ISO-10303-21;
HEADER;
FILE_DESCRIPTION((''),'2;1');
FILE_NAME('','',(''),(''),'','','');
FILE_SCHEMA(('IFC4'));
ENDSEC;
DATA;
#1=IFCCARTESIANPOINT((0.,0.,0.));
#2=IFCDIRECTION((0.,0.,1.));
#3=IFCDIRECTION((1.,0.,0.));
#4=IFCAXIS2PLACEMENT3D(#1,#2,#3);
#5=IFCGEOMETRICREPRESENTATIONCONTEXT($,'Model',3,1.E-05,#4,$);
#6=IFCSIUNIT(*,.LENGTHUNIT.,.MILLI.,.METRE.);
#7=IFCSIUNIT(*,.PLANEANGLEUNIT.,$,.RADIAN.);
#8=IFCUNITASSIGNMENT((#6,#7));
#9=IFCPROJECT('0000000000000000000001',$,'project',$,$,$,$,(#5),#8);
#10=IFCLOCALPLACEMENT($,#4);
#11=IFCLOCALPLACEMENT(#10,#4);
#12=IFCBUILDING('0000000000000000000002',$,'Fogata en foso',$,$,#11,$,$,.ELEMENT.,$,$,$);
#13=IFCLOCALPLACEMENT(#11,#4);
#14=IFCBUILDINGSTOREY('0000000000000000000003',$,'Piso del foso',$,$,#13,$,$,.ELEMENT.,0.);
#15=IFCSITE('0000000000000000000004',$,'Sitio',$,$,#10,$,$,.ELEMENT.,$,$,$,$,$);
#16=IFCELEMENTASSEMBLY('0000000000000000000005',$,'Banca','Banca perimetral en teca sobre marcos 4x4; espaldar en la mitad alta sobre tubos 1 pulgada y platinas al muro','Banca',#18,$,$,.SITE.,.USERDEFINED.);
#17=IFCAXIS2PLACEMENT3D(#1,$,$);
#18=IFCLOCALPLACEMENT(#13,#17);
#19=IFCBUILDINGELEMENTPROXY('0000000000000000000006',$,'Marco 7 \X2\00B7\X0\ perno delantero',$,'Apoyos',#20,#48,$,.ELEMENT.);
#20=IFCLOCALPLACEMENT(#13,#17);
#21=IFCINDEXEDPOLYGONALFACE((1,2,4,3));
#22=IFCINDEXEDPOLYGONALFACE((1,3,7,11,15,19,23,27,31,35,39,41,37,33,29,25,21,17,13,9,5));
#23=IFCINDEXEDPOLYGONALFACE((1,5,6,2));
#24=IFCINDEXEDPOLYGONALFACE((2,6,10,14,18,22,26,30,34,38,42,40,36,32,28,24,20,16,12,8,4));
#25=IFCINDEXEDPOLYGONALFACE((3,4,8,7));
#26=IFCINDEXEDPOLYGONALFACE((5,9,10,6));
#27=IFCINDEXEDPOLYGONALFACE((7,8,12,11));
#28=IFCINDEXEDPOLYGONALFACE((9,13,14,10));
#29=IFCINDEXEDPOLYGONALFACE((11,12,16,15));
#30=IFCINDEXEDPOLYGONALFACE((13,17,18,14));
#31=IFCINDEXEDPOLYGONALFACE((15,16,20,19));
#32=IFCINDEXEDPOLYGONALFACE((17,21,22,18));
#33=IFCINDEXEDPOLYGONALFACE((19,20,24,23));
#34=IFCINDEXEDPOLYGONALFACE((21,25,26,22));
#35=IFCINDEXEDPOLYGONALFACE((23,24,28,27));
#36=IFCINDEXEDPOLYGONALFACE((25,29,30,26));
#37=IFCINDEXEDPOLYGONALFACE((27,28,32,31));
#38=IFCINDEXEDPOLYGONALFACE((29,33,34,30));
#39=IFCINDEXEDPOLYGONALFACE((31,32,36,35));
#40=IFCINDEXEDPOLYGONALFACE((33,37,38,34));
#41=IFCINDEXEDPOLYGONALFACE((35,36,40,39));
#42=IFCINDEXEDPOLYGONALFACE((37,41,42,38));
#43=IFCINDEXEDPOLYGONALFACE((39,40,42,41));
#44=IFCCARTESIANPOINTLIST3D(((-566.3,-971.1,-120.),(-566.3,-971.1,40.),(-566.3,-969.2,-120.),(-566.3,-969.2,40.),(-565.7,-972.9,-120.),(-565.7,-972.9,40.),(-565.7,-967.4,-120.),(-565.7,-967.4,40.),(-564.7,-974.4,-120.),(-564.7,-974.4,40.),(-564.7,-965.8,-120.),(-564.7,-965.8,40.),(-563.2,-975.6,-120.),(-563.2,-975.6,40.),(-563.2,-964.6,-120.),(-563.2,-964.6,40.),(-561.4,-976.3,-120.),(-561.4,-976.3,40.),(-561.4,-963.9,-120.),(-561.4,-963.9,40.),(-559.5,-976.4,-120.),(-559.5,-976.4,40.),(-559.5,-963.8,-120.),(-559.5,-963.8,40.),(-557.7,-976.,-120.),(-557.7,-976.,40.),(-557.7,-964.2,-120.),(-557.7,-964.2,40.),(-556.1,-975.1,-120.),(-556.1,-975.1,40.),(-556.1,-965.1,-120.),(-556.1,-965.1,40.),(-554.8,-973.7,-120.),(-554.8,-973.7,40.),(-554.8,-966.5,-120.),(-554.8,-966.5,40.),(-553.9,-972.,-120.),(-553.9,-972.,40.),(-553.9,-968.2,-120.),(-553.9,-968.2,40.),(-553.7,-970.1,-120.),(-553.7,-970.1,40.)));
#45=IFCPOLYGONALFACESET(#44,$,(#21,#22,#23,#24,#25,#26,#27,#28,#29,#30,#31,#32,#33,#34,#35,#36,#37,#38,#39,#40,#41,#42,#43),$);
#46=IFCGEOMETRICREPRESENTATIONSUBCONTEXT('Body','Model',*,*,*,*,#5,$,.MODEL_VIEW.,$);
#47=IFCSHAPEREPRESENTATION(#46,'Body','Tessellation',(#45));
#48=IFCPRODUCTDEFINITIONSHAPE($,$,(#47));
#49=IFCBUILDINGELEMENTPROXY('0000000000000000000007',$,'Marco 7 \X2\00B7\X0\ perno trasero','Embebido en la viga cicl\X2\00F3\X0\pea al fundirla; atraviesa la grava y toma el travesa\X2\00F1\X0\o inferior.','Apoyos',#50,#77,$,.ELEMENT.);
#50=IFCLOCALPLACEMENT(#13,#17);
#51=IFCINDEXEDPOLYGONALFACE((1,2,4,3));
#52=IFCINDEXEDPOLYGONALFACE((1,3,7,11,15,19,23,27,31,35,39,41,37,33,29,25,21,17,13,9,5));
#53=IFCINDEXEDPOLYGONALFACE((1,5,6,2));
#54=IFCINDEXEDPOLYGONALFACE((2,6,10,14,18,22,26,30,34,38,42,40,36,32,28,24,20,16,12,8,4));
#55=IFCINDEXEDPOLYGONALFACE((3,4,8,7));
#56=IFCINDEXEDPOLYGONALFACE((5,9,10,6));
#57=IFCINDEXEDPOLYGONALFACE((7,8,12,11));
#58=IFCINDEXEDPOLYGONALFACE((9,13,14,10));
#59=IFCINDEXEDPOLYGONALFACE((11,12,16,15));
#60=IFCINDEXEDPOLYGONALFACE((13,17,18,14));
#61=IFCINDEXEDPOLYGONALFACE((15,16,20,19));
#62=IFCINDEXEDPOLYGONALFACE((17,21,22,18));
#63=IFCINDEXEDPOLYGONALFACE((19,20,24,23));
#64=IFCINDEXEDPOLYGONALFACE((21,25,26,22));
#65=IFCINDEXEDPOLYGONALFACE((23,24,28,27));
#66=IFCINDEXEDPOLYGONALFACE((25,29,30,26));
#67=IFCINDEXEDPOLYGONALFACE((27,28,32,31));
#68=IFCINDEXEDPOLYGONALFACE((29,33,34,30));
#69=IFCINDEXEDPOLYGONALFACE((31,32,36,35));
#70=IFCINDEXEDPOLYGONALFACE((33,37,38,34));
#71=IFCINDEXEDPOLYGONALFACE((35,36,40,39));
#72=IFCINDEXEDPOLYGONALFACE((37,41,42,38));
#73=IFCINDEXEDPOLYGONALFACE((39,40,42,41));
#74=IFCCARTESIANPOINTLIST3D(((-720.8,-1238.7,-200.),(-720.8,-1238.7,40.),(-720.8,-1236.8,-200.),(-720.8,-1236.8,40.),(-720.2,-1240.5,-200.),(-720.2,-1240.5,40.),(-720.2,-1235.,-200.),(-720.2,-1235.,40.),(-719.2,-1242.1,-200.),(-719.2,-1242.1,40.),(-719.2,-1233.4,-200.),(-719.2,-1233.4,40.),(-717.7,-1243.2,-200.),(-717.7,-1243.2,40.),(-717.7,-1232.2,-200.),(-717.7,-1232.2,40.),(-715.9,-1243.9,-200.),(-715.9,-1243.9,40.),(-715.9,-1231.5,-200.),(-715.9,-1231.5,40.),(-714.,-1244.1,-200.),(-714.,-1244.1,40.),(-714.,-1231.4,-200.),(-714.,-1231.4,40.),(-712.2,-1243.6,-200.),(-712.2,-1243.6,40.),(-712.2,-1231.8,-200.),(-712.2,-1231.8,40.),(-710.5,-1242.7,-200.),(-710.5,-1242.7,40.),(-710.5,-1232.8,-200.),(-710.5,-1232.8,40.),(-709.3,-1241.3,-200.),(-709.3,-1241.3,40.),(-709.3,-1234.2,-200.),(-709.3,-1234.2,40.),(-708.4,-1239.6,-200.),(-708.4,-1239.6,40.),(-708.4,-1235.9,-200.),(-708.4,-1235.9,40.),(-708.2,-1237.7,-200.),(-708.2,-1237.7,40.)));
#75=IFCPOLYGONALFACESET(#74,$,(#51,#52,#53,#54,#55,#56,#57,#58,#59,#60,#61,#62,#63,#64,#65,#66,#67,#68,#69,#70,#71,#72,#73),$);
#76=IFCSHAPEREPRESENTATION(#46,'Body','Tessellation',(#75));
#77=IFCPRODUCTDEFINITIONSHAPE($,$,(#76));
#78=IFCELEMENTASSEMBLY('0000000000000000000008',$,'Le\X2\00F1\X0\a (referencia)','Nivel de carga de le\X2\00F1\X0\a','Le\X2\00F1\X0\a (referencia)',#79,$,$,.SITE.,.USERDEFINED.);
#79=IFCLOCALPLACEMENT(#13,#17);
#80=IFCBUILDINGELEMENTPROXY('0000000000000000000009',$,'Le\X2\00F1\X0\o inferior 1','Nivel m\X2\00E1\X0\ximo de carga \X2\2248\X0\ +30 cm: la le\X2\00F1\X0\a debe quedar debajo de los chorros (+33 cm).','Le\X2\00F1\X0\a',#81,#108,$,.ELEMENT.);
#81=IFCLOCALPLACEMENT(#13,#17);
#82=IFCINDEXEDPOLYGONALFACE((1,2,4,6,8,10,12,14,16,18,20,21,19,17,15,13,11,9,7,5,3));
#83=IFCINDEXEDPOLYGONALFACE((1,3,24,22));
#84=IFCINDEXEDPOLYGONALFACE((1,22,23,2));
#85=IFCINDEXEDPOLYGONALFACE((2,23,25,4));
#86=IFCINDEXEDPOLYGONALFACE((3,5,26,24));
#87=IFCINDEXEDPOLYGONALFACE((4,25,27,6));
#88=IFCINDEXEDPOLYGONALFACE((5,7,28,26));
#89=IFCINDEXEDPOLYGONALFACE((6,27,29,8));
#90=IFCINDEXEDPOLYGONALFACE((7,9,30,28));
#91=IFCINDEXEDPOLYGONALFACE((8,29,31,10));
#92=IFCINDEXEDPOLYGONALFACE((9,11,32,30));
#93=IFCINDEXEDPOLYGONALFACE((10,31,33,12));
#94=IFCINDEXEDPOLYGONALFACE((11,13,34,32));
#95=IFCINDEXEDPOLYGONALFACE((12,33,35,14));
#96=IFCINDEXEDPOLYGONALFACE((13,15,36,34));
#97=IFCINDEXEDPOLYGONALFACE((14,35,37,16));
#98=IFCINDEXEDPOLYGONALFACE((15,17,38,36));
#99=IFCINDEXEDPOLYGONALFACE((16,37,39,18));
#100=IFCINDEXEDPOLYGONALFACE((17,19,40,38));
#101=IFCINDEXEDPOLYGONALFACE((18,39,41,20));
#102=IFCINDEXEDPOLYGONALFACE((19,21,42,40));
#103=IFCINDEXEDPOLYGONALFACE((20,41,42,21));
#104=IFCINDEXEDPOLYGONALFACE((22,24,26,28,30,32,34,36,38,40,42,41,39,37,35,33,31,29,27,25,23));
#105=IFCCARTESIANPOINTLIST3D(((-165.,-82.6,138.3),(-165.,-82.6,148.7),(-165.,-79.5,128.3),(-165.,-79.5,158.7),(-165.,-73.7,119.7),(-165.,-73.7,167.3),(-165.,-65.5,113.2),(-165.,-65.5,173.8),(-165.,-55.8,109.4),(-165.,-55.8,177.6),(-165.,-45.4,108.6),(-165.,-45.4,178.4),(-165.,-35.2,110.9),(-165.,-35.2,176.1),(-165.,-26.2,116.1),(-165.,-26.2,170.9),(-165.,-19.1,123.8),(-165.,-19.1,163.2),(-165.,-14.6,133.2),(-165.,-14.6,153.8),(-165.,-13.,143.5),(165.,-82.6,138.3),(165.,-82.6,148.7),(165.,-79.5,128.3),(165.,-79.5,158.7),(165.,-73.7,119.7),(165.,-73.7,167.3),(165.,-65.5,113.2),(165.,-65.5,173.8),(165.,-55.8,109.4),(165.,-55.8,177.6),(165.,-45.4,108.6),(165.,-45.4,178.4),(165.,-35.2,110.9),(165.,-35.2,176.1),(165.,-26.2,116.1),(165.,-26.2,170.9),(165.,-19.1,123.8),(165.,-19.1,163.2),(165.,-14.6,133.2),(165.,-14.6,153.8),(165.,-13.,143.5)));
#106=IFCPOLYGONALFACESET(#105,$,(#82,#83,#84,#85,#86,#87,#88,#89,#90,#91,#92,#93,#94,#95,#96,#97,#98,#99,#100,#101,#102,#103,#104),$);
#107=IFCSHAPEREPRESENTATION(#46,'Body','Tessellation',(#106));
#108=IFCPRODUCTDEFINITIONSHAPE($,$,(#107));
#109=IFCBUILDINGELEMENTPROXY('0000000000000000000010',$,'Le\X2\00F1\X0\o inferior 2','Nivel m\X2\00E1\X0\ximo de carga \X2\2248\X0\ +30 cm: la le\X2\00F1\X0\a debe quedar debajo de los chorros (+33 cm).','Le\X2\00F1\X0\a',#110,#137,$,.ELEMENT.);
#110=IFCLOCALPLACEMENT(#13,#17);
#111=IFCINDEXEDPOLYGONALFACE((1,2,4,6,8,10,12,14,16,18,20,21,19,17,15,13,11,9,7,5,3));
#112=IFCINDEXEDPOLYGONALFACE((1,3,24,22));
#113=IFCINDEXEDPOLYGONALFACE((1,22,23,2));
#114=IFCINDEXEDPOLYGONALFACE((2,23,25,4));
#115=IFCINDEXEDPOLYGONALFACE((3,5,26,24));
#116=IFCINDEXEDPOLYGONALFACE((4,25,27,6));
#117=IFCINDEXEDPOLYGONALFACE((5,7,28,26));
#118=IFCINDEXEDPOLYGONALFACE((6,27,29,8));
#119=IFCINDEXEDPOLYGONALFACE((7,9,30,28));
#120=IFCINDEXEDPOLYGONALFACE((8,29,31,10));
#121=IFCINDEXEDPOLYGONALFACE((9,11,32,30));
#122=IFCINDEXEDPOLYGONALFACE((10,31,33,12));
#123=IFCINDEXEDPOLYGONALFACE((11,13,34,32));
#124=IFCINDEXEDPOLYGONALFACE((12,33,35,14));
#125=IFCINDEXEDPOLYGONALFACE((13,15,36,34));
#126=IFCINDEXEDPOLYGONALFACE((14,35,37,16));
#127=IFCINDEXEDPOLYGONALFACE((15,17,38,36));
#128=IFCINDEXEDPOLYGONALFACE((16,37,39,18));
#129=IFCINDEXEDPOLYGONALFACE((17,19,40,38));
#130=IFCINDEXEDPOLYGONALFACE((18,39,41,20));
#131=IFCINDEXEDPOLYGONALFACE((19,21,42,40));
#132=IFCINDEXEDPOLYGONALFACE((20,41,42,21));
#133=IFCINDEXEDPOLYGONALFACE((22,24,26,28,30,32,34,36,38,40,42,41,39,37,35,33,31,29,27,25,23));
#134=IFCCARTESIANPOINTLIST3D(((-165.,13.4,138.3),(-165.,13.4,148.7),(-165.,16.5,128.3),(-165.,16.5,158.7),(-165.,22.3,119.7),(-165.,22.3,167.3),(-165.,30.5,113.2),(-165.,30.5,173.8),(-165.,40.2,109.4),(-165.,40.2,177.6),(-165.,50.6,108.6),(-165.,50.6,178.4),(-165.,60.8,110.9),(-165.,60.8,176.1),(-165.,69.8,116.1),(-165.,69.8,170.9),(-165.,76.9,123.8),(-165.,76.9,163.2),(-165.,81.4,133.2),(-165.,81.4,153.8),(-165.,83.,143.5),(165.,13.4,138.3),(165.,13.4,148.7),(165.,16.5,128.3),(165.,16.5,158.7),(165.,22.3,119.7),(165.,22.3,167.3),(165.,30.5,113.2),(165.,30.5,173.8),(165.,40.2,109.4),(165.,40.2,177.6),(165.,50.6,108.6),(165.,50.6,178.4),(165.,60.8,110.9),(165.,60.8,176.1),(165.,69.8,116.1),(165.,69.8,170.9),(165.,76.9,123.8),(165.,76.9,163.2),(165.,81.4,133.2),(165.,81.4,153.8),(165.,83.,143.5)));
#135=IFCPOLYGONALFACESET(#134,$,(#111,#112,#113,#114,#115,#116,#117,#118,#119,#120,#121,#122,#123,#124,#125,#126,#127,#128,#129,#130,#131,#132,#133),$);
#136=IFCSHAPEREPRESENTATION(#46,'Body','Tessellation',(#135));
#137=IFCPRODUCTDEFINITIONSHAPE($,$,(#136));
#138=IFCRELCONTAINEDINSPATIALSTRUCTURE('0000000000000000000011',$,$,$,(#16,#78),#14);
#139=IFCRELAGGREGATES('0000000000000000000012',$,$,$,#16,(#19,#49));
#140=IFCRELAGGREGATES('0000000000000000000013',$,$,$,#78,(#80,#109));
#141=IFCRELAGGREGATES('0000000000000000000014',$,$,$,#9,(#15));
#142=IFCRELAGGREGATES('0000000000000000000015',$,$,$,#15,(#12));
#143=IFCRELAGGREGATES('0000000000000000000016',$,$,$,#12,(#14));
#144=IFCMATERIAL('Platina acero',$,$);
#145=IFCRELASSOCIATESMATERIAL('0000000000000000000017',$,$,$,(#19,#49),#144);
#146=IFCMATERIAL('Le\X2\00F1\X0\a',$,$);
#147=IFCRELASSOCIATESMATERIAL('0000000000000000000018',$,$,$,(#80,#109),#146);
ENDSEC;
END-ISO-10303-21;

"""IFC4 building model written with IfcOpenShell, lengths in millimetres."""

from ifc_helpers import new_model, si_unit, frame, origin_with_axes, origin_2d, place, context, subcontext, project, spatial, circle, extrude, material, element, aggregate, save


model = new_model("IFC4")

# Units and contexts
model_context = context("Model", 3, precision=1e-05, world=origin_with_axes())
body_context = subcontext(model_context, "Body", "Model", "MODEL_VIEW")
ifc_project = project(units=[si_unit("LENGTHUNIT", "METRE", prefix="MILLI"), si_unit("PLANEANGLEUNIT", "RADIAN")], contexts=[model_context])

# Site, building, storey
site_placement = place(None, origin_with_axes())
site = spatial("IfcSite", under=ifc_project, at=site_placement, Name="Sitio", CompositionType="ELEMENT")
building_placement = place(site_placement, origin_with_axes())
building = spatial("IfcBuilding", under=site, at=building_placement, Name="Fogata en foso", CompositionType="ELEMENT")
storey_placement = place(building_placement, origin_with_axes())
storey = spatial("IfcBuildingStorey", under=building, at=storey_placement, Name="Piso del foso", CompositionType="ELEMENT", Elevation=0.0)

# Element assembly, building element proxies
assembly_1_placement = place(storey_placement, origin_with_axes())
assembly_1 = element("IfcElementAssembly", 1, at=assembly_1_placement, inside=storey, Name="Banca", Description="Banca perimetral en teca sobre marcos 4x4; espaldar en la mitad alta sobre tubos 1 pulgada y platinas al muro", ObjectType="Banca", AssemblyPlace="SITE", PredefinedType="USERDEFINED")
ifc_material_1 = material(Name="Platina acero")
proxy_1_placement = place(storey_placement, frame((-560.0, -970.1, -120.0), z_axis=(0.0, 0.0, 1.0), x_axis=(1.0, 0.0, 0.0)))
proxy_1 = element("IfcBuildingElementProxy", 2, at=proxy_1_placement, material=ifc_material_1, Name="Marco 7 · perno delantero", ObjectType="Apoyos", PredefinedType="ELEMENT", context=body_context, shape_type="SweptSolid", body=[
    extrude(circle(Radius=6.3, at=origin_2d()), origin_with_axes(), (0.0, 0.0, 1.0), 160.0),
])
proxy_2_placement = place(storey_placement, frame((-714.5, -1237.7, -200.0), z_axis=(0.0, 0.0, 1.0), x_axis=(1.0, 0.0, 0.0)))
proxy_2 = element("IfcBuildingElementProxy", 3, at=proxy_2_placement, material=ifc_material_1, Name="Marco 7 · perno trasero", Description="Embebido en la viga ciclópea al fundirla; atraviesa la grava y toma el travesaño inferior.", ObjectType="Apoyos", PredefinedType="ELEMENT", context=body_context, shape_type="SweptSolid", body=[
    extrude(circle(Radius=6.3, at=origin_2d()), origin_with_axes(), (0.0, 0.0, 1.0), 240.0),
])
aggregate(assembly_1, [proxy_1, proxy_2])

# Element assembly, building element proxies
assembly_2_placement = place(storey_placement, origin_with_axes())
assembly_2 = element("IfcElementAssembly", 4, at=assembly_2_placement, inside=storey, Name="Leña (referencia)", Description="Nivel de carga de leña", ObjectType="Leña (referencia)", AssemblyPlace="SITE", PredefinedType="USERDEFINED")
ifc_material_2 = material(Name="Leña")
proxy_3_placement = place(storey_placement, frame((-165.0, -48.0, 143.5), z_axis=(1.0, 0.0, 0.0), x_axis=(0.0, 1.0, 0.0)))
proxy_3 = element("IfcBuildingElementProxy", 5, at=proxy_3_placement, material=ifc_material_2, Name="Leño inferior 1", Description="Nivel máximo de carga ≈ +30 cm: la leña debe quedar debajo de los chorros (+33 cm).", ObjectType="Leña", PredefinedType="ELEMENT", context=body_context, shape_type="SweptSolid", body=[
    extrude(circle(Radius=35.0, at=origin_2d()), origin_with_axes(), (0.0, 0.0, 1.0), 330.0),
])
proxy_4_placement = place(storey_placement, frame((-165.0, 48.0, 143.5), z_axis=(1.0, 0.0, 0.0), x_axis=(0.0, 1.0, 0.0)))
proxy_4 = element("IfcBuildingElementProxy", 6, at=proxy_4_placement, material=ifc_material_2, Name="Leño inferior 2", Description="Nivel máximo de carga ≈ +30 cm: la leña debe quedar debajo de los chorros (+33 cm).", ObjectType="Leña", PredefinedType="ELEMENT", context=body_context, shape_type="SweptSolid", body=[
    extrude(circle(Radius=35.0, at=origin_2d()), origin_with_axes(), (0.0, 0.0, 1.0), 330.0),
])
aggregate(assembly_2, [proxy_3, proxy_4])

save(model, "model.ifc")
